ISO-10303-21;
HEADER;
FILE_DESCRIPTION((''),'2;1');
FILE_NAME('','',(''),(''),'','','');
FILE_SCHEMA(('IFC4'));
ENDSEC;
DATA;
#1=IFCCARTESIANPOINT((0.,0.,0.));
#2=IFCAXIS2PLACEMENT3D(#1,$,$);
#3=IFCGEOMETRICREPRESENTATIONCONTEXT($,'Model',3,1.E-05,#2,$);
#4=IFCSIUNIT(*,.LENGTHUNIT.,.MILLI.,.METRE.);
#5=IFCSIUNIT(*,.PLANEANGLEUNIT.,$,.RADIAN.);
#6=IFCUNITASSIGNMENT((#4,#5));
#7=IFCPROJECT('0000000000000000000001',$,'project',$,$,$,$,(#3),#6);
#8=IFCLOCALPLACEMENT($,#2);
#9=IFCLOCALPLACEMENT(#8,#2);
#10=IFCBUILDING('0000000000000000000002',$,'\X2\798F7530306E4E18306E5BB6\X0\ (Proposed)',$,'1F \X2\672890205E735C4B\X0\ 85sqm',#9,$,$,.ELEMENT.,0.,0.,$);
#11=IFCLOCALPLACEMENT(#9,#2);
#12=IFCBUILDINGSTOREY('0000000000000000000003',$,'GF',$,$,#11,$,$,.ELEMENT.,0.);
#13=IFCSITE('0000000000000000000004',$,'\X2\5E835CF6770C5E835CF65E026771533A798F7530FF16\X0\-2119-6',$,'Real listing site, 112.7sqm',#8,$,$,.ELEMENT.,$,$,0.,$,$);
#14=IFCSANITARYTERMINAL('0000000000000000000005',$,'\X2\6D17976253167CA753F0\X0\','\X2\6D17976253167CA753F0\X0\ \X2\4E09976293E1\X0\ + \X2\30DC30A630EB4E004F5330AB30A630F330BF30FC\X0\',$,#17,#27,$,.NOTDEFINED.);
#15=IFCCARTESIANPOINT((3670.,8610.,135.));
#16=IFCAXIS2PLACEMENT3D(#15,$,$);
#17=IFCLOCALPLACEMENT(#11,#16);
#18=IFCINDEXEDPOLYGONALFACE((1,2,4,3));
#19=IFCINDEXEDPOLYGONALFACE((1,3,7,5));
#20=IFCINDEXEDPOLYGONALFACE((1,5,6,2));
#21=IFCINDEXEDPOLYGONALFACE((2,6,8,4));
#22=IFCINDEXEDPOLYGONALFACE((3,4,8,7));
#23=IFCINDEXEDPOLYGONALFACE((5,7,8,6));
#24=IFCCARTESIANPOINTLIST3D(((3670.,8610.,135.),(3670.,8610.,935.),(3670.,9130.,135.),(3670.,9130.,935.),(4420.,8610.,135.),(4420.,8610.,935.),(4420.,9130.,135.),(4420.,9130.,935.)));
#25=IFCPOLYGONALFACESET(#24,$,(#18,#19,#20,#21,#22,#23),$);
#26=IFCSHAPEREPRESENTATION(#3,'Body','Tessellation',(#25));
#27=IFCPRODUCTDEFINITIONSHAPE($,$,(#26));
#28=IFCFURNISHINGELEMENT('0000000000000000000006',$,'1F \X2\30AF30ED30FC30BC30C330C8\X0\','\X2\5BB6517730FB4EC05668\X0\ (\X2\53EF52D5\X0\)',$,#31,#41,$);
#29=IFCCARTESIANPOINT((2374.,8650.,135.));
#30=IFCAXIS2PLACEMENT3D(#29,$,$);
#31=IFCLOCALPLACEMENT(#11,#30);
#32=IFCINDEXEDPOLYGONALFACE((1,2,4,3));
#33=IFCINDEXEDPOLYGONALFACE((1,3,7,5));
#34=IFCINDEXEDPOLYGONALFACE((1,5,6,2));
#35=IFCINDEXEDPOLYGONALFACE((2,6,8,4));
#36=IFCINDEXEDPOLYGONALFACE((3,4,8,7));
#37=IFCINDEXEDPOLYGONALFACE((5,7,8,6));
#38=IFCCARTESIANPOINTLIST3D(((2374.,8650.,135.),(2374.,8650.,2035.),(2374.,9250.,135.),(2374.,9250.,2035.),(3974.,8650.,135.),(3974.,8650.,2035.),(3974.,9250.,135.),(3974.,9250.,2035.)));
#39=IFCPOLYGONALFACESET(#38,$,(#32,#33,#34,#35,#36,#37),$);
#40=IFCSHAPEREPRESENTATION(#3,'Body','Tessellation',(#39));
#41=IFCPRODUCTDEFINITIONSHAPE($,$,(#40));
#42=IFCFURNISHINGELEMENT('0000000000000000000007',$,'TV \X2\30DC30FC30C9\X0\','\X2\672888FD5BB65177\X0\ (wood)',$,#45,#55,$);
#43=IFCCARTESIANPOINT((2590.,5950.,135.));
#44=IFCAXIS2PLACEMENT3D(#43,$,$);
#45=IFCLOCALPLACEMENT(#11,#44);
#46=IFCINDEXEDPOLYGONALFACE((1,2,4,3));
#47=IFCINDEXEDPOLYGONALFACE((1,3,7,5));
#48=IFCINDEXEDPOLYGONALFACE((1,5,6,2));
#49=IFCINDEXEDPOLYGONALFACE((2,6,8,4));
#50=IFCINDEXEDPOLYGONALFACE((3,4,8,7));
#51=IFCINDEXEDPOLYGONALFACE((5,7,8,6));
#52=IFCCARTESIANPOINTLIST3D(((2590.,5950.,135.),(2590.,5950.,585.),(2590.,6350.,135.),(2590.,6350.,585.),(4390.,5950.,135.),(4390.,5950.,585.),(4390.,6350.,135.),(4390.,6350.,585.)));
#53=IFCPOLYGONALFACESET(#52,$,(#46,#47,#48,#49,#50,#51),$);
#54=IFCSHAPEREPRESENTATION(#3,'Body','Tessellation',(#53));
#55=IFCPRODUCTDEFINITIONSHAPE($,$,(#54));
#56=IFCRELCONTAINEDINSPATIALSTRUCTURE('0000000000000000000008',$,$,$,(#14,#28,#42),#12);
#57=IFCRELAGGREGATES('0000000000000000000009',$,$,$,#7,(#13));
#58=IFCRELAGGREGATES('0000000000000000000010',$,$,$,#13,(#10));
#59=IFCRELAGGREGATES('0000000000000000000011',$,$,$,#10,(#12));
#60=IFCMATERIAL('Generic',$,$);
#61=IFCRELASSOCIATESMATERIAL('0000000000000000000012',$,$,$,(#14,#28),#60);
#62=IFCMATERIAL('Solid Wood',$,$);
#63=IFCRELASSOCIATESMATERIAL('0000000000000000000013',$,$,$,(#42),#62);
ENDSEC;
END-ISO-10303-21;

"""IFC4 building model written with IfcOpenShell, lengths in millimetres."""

from ifc_helpers import new_model, si_unit, frame, frame_2d, origin, place, context, project, spatial, rectangle, extrude, material, element, save


model = new_model("IFC4")

# Units and contexts
model_context = context("Model", 3, precision=1e-05, world=origin())
ifc_project = project(units=[si_unit("LENGTHUNIT", "METRE", prefix="MILLI"), si_unit("PLANEANGLEUNIT", "RADIAN")], contexts=[model_context])

# Site, building, storey
site_placement = place(None, origin())
site = spatial("IfcSite", under=ifc_project, at=site_placement, Name="広島県広島市東区福田６-2119-6", ObjectType="Real listing site, 112.7sqm", CompositionType="ELEMENT", RefElevation=0.0)
building_placement = place(site_placement, origin())
building = spatial("IfcBuilding", under=site, at=building_placement, Name="福田の丘の家 (Proposed)", ObjectType="1F 木造平屋 85sqm", CompositionType="ELEMENT", ElevationOfRefHeight=0.0, ElevationOfTerrain=0.0)
storey_placement = place(building_placement, origin())
storey = spatial("IfcBuildingStorey", under=building, at=storey_placement, Name="GF", CompositionType="ELEMENT", Elevation=0.0)

# Shared definitions
ifc_material_1 = material(Name="Solid Wood")

# Shared definitions
ifc_material_2 = material(Name="Generic")

# Sanitary terminal
sanitary_terminal_1_placement = place(storey_placement, frame((3670.0, 8610.0, 135.0)))
element("IfcSanitaryTerminal", 1, at=sanitary_terminal_1_placement, inside=storey, material=ifc_material_2, Name="洗面化粧台", Description="洗面化粧台 三面鏡 + ボウル一体カウンター", PredefinedType="NOTDEFINED", context=model_context, shape_type="SweptSolid", body=[
    extrude(rectangle(XDim=750.0, YDim=520.0, at=frame_2d((375.0, 260.0))), frame((3670.0, 8610.0, 135.0)), (0.0, 0.0, 1.0), 800.0),
])

# Furnishing elements
furnishing_1_placement = place(storey_placement, frame((2374.0, 8650.0, 135.0)))
element("IfcFurnishingElement", 2, at=furnishing_1_placement, inside=storey, material=ifc_material_2, Name="1F クローゼット", Description="家具・什器 (可動)", context=model_context, shape_type="SweptSolid", body=[
    extrude(rectangle(XDim=1600.0, YDim=600.0, at=frame_2d((800.0, 300.0))), frame((2374.0, 8650.0, 135.0)), (0.0, 0.0, 1.0), 1900.0),
])
furnishing_2_placement = place(storey_placement, frame((2590.0, 5950.0, 135.0)))
element("IfcFurnishingElement", 3, at=furnishing_2_placement, inside=storey, material=ifc_material_1, Name="TV ボード", Description="木製家具 (wood)", context=model_context, shape_type="SweptSolid", body=[
    extrude(rectangle(XDim=1800.0, YDim=400.0, at=frame_2d((900.0, 200.0))), frame((2590.0, 5950.0, 135.0)), (0.0, 0.0, 1.0), 450.0),
])

save(model, "model.ifc")
